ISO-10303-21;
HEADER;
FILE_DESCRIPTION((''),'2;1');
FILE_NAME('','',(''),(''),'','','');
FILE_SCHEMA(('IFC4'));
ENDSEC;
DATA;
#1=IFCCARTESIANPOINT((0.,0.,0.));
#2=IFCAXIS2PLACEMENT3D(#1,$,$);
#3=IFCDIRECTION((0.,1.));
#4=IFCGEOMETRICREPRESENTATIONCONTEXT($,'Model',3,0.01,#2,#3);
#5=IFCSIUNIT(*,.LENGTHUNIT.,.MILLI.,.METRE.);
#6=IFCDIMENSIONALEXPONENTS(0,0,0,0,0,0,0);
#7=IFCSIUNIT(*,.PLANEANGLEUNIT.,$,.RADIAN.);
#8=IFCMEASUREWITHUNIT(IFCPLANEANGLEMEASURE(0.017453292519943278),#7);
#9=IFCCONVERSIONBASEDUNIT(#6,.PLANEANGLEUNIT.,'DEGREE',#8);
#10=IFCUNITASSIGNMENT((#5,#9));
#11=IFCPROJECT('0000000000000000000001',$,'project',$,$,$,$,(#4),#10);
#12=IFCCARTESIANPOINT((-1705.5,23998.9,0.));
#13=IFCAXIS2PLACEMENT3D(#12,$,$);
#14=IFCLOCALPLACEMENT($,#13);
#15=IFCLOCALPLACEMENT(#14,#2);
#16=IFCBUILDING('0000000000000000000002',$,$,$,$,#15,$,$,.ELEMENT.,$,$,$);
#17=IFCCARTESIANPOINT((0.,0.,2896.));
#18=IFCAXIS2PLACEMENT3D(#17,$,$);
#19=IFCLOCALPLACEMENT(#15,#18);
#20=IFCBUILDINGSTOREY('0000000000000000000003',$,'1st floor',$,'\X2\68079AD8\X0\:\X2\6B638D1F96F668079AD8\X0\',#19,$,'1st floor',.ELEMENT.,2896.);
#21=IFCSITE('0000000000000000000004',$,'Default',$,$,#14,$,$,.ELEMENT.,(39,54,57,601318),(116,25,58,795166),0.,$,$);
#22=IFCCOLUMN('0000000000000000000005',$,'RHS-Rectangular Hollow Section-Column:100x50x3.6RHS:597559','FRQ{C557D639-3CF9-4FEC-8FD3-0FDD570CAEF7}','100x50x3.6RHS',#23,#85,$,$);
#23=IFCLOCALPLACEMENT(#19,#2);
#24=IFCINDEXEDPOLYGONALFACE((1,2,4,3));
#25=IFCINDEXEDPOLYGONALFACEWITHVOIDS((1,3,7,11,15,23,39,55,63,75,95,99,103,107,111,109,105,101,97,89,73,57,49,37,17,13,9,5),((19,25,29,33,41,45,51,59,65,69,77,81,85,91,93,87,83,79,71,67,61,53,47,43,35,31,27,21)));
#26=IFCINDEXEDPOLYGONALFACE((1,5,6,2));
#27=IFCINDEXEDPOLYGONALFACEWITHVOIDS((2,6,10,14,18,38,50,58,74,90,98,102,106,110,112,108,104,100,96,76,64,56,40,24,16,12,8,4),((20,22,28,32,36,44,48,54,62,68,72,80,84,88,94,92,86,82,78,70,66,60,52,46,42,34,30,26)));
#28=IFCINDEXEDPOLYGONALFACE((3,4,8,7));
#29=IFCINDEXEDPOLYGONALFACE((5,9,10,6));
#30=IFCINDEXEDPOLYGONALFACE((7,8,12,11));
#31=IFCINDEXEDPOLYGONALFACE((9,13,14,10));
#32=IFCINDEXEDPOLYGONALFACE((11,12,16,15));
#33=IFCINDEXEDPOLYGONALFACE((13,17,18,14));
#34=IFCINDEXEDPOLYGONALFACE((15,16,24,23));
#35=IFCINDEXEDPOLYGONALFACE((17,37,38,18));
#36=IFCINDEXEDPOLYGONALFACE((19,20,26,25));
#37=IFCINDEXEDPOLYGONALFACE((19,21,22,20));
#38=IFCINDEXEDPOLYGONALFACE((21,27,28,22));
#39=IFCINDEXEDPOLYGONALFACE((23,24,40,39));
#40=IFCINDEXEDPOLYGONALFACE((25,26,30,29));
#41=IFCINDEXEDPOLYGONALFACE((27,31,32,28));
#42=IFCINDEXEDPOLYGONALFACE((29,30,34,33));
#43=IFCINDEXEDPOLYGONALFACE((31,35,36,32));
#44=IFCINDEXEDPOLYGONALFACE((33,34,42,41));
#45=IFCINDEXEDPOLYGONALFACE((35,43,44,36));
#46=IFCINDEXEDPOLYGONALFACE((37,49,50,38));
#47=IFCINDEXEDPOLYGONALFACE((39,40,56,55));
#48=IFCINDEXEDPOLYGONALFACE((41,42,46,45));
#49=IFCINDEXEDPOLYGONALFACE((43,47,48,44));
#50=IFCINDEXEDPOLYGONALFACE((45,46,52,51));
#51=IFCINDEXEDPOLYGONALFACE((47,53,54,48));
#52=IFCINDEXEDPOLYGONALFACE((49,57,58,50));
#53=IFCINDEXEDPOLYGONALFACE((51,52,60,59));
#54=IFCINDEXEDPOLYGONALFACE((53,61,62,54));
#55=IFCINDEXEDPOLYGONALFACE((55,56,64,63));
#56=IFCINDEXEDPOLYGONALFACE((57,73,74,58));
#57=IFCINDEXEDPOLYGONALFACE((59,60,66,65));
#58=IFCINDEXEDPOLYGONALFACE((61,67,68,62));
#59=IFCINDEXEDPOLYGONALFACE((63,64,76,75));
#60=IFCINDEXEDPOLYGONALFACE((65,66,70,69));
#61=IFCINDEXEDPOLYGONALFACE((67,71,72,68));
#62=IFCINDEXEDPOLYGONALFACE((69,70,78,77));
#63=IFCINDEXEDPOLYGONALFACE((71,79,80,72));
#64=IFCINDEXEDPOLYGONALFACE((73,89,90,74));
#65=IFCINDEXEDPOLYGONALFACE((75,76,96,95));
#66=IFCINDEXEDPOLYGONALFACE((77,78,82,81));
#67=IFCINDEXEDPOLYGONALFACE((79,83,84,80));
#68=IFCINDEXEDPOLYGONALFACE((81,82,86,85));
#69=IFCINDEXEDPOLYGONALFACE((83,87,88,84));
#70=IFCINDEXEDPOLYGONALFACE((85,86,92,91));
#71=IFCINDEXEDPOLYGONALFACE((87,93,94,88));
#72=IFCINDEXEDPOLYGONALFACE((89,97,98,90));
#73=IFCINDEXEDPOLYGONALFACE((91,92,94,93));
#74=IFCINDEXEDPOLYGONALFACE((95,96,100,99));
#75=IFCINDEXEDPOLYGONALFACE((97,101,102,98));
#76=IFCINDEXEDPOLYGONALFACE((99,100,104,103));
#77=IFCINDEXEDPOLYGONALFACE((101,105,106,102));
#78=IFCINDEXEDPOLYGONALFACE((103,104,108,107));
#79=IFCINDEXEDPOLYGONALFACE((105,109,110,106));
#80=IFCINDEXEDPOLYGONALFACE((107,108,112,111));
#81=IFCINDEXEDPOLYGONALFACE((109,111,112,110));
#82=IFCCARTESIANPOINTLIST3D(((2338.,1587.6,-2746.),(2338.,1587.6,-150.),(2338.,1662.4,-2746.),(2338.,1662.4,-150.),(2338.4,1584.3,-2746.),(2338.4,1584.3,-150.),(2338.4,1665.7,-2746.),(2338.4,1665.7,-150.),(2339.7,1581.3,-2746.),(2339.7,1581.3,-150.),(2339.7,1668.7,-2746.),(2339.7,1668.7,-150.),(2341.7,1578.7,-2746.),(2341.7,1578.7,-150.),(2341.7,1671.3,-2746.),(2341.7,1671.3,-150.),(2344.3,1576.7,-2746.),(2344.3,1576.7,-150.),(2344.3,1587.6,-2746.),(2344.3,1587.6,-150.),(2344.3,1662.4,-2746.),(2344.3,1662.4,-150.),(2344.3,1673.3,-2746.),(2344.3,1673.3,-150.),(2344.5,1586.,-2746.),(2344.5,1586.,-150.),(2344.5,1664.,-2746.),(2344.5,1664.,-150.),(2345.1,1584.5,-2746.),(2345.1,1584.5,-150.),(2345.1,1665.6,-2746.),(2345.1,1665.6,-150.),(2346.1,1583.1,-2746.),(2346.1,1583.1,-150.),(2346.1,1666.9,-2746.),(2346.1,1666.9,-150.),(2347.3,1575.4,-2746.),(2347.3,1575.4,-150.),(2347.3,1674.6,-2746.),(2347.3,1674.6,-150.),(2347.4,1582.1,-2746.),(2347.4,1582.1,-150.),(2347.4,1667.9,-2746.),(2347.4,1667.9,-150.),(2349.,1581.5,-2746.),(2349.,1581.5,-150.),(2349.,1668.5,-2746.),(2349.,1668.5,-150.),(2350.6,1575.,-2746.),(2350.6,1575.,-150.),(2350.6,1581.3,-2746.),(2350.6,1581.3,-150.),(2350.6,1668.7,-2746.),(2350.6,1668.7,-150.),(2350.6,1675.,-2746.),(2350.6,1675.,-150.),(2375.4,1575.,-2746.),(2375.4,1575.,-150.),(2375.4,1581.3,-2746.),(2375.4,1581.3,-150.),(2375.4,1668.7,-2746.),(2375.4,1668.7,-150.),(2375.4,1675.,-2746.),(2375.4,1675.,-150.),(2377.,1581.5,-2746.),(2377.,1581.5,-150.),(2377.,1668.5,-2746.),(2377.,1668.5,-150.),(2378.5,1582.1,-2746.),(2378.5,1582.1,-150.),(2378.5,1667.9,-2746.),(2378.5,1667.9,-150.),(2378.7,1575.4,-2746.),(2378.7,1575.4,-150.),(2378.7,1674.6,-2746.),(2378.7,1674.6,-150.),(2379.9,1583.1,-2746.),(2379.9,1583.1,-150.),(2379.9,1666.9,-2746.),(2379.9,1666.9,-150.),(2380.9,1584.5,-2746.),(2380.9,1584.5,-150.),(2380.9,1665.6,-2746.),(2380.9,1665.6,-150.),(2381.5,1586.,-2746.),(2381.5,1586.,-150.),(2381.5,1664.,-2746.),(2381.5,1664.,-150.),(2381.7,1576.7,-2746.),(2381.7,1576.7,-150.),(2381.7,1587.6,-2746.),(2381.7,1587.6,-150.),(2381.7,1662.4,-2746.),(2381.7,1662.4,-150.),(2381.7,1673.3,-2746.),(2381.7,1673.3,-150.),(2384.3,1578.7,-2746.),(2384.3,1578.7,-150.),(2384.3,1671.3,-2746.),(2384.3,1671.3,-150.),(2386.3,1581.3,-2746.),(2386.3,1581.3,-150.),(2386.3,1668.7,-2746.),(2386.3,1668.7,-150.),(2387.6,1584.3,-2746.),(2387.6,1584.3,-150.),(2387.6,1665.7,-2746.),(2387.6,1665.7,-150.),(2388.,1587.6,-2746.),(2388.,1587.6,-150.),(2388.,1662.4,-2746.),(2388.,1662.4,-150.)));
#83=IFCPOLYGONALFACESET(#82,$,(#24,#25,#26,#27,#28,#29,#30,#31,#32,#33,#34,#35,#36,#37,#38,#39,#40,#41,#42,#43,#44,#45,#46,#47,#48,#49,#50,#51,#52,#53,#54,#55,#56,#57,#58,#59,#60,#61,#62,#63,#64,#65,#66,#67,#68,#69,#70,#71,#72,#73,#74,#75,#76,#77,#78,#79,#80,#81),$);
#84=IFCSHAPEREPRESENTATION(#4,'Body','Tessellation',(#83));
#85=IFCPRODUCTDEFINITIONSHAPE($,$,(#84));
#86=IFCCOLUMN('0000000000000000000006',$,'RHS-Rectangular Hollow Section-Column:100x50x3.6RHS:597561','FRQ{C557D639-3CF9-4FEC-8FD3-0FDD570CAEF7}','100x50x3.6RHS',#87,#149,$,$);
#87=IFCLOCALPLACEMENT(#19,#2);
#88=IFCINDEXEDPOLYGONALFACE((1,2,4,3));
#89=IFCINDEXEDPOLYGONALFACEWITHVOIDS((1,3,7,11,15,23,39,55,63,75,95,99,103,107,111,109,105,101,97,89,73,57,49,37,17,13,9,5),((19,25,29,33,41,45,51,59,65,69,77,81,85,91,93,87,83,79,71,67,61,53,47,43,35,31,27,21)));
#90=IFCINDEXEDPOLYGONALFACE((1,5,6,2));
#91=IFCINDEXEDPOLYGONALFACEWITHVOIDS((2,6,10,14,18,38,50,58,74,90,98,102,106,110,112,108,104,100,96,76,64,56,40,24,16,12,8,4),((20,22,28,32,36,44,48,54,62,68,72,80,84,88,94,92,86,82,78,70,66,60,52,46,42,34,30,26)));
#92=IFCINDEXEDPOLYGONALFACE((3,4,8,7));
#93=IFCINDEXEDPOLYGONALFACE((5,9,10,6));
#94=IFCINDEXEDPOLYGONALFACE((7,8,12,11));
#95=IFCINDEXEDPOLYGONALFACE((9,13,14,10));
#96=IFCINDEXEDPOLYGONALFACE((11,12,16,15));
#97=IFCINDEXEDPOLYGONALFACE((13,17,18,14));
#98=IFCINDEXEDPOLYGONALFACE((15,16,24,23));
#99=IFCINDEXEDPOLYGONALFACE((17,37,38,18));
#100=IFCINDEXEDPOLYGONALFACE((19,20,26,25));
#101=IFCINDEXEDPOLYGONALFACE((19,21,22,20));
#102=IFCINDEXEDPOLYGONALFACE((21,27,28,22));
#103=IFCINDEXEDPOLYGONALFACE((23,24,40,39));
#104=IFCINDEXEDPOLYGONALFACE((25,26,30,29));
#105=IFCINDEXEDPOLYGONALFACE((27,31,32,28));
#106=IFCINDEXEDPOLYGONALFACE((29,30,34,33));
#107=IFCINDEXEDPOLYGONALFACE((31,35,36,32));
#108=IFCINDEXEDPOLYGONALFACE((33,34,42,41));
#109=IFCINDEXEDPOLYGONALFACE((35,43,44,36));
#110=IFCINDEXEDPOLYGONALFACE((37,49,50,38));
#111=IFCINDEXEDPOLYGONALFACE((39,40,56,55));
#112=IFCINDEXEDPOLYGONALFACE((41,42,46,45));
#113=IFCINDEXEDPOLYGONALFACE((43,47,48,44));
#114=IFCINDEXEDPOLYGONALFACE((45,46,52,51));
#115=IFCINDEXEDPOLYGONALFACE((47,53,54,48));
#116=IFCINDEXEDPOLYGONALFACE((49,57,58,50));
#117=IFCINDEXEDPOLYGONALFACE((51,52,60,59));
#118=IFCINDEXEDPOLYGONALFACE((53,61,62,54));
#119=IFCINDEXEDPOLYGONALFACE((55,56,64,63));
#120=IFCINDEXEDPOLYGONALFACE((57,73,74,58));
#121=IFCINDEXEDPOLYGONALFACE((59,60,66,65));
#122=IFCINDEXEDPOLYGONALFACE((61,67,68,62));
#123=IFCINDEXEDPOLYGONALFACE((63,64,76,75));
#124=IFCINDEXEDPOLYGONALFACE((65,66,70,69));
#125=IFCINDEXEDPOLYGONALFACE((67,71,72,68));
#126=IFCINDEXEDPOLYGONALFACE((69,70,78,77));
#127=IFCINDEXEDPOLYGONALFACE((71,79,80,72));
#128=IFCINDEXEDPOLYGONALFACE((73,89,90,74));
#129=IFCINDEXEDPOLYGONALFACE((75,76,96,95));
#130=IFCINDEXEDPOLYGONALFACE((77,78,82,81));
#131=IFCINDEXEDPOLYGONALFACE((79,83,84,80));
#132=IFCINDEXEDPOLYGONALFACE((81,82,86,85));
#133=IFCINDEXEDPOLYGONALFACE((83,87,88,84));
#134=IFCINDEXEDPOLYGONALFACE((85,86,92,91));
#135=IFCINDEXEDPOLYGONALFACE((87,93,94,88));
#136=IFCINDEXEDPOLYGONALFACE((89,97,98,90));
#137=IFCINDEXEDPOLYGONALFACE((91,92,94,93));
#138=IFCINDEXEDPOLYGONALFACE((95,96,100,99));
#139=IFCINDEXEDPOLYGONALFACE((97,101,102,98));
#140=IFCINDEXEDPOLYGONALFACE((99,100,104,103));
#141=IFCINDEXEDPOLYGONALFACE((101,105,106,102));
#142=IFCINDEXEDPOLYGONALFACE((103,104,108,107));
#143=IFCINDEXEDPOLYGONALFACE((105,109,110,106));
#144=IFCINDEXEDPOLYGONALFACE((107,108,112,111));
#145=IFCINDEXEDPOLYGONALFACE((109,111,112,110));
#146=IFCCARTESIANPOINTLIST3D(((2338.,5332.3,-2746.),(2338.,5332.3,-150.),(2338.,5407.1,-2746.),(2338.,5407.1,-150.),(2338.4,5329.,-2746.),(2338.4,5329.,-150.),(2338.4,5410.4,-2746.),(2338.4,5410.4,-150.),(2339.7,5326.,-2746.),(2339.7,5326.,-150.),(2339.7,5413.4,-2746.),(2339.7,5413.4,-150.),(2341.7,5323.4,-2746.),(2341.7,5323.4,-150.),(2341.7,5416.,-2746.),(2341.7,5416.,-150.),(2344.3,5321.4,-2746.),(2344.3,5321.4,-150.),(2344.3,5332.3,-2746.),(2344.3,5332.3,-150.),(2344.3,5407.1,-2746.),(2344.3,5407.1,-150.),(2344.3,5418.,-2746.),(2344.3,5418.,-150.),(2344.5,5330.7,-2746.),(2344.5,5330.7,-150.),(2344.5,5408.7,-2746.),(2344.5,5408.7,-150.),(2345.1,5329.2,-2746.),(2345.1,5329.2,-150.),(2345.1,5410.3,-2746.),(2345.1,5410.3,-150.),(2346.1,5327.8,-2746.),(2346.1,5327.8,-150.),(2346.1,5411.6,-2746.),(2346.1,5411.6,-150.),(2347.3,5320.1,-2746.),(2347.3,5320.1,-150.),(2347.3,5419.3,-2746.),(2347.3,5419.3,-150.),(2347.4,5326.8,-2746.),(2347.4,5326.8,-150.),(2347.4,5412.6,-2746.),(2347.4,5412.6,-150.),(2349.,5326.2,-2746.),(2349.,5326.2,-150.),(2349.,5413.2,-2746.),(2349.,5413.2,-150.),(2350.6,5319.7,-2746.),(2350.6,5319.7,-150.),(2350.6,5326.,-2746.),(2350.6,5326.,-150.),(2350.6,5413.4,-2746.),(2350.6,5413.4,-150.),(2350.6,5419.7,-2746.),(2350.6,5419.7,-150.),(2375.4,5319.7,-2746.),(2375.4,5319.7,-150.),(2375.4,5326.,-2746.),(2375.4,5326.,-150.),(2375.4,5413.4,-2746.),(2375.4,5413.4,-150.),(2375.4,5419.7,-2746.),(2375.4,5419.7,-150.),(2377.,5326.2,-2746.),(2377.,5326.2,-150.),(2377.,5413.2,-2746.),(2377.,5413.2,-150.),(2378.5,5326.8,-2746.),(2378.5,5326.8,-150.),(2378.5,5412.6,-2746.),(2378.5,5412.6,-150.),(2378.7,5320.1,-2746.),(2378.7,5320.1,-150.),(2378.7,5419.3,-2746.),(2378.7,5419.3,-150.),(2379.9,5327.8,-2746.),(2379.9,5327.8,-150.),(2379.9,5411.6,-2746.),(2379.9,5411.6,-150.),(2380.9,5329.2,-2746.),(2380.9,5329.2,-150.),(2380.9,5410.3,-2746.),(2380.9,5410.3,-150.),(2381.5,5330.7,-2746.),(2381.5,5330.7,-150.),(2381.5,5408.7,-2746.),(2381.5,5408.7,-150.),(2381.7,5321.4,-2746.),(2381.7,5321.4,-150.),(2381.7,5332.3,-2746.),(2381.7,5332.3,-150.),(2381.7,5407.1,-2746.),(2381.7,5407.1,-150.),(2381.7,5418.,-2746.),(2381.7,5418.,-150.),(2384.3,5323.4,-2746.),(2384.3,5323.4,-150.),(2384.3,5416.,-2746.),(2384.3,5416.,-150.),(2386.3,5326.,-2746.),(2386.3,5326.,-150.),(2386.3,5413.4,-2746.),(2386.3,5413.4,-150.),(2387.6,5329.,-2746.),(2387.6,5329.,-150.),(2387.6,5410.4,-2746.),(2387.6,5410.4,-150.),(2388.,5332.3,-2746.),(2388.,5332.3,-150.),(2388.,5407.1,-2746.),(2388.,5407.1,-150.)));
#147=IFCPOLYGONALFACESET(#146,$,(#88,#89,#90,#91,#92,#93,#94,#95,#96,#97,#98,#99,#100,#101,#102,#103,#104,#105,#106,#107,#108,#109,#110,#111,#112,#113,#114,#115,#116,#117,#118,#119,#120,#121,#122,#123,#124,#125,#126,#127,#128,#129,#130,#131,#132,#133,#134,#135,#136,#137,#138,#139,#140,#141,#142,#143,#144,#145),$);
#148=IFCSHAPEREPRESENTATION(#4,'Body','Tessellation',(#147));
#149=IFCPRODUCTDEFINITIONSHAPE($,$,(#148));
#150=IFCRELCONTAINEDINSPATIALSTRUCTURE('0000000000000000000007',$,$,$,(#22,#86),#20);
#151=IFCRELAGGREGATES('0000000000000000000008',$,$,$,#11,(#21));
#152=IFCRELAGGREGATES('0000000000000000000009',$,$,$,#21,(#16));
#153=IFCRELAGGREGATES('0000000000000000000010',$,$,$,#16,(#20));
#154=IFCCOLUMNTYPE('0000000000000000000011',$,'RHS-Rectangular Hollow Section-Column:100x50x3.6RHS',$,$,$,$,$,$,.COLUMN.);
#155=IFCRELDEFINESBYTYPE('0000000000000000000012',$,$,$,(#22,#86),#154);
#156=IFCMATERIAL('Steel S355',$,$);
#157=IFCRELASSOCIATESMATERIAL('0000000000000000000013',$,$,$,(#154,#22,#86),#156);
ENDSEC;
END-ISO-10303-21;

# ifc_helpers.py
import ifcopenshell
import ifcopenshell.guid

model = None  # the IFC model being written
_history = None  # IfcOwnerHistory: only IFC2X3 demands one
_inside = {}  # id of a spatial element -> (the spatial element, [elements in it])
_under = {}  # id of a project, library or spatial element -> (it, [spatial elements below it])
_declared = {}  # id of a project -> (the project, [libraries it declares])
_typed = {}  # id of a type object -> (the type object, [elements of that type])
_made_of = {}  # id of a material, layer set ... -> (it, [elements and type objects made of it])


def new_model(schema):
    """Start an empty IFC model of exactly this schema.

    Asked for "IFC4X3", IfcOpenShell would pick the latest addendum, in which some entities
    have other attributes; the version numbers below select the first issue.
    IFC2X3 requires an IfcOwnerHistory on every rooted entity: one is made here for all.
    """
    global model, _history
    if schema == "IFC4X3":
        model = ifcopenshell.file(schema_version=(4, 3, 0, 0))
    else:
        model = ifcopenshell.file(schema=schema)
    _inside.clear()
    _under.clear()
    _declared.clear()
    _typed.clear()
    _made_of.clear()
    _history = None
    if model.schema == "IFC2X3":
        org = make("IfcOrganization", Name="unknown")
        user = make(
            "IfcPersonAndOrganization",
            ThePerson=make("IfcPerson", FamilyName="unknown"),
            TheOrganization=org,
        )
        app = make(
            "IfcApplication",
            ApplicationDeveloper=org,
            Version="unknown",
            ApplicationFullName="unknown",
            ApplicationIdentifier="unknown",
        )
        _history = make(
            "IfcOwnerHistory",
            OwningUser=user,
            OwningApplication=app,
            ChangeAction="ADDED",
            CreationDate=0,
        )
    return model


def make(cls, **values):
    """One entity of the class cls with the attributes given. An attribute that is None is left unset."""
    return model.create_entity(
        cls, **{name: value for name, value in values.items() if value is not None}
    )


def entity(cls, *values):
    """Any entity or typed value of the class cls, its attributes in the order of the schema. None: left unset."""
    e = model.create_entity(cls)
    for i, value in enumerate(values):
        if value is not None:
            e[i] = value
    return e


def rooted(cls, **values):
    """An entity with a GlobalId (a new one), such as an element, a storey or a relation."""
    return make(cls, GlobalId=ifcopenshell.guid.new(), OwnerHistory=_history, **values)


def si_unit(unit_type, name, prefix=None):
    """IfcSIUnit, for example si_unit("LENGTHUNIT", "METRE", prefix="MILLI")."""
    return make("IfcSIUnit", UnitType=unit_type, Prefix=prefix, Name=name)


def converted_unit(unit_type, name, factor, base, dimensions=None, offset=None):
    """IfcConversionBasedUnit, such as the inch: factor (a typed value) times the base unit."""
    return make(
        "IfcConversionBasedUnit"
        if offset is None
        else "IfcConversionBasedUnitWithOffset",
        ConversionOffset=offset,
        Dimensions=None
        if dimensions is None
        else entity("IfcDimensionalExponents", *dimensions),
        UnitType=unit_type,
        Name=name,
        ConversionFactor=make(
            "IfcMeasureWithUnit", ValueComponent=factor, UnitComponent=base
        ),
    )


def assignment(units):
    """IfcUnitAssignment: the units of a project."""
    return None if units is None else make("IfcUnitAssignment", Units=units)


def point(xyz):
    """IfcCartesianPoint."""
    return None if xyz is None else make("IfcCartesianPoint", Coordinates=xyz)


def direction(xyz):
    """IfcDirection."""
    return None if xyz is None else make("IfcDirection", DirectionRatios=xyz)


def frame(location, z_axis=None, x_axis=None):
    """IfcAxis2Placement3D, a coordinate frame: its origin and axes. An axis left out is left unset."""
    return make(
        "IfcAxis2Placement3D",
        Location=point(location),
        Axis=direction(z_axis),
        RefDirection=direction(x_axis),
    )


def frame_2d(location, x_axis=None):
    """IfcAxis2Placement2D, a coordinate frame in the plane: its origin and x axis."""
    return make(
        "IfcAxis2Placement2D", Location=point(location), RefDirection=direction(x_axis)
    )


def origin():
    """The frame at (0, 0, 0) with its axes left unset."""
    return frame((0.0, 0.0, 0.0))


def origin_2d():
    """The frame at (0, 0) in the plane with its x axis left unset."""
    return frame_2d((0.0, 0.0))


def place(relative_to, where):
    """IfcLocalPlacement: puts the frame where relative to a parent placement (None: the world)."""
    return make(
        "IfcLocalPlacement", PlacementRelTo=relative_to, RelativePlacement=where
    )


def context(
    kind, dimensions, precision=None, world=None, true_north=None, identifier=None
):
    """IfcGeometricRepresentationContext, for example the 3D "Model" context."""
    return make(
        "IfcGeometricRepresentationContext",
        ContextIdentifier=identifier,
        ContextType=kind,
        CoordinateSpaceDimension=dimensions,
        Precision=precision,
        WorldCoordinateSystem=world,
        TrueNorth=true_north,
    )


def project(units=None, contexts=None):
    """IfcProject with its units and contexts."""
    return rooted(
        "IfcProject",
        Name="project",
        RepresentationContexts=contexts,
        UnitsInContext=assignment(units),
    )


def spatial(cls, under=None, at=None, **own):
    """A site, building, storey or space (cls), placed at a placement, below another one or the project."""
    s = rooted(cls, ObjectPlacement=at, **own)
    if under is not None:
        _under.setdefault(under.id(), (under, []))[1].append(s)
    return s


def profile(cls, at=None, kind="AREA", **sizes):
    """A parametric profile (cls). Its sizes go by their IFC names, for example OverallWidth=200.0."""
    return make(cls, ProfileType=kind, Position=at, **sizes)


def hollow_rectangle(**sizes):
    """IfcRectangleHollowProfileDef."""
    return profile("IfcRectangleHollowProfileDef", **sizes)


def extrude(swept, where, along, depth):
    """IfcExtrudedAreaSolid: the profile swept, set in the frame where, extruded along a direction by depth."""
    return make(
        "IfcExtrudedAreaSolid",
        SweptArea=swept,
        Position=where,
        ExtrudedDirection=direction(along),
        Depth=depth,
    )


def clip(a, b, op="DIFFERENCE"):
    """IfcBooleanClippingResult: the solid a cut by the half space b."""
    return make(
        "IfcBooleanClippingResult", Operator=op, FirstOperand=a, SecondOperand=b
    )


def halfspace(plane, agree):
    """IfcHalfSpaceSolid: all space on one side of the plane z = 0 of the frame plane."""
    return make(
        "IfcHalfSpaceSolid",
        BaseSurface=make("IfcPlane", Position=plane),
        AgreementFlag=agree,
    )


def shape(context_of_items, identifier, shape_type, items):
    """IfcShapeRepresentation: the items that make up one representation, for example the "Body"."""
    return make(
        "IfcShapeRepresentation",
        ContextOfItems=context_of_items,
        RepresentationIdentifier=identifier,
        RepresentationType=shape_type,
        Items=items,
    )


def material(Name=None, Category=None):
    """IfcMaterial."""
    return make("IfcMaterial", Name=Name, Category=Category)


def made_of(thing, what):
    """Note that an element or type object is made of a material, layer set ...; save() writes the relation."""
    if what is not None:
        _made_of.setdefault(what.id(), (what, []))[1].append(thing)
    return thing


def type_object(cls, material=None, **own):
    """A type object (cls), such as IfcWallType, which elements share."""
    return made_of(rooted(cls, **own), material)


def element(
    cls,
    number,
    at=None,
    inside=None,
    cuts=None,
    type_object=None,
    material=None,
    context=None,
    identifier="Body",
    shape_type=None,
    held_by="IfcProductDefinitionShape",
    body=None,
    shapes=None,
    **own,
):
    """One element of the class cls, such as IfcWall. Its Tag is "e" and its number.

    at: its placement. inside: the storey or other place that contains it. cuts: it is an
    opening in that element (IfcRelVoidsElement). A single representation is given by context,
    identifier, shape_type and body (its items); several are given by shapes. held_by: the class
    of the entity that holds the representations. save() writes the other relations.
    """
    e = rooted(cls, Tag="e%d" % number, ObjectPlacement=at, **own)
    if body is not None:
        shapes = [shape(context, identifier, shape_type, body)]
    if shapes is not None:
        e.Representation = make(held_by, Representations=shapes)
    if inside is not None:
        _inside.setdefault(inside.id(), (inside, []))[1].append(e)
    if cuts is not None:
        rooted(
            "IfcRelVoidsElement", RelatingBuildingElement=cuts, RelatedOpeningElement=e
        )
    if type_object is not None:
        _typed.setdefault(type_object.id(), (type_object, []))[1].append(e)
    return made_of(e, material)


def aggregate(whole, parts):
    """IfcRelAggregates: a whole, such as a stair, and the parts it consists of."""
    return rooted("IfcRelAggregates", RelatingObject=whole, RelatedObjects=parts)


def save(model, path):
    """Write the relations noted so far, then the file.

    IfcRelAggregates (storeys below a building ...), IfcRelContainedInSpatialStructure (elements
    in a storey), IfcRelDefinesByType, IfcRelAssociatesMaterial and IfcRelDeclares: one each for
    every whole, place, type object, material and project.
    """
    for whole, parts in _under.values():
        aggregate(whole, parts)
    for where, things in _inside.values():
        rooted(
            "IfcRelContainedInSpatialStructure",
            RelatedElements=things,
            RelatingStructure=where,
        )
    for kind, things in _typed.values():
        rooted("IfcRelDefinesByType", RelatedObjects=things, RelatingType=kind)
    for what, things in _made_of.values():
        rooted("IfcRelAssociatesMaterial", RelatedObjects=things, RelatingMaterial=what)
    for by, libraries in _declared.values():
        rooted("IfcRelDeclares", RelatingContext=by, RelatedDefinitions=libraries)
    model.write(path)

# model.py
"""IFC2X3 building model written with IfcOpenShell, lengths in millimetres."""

from ifc_helpers import new_model, entity, si_unit, converted_unit, direction, frame, origin, origin_2d, place, context, project, spatial, hollow_rectangle, extrude, clip, halfspace, material, type_object, element, save


model = new_model("IFC2X3")

# Units and contexts
model_context = context("Model", 3, precision=0.01, world=origin(), true_north=direction((0.0, 1.0)))
ifc_project = project(units=[si_unit("LENGTHUNIT", "METRE", prefix="MILLI"), converted_unit("PLANEANGLEUNIT", "DEGREE", entity("IfcPlaneAngleMeasure", 0.017453292519943278), si_unit("PLANEANGLEUNIT", "RADIAN"), dimensions=[0, 0, 0, 0, 0, 0, 0])], contexts=[model_context])

# Site, building, storey
site_placement = place(None, frame((-1705.5, 23998.9, 0.0)))
site = spatial("IfcSite", under=ifc_project, at=site_placement, Name="Default", CompositionType="ELEMENT", RefLatitude=(39, 54, 57, 601318), RefLongitude=(116, 25, 58, 795166), RefElevation=0.0)
building_placement = place(site_placement, origin())
building = spatial("IfcBuilding", under=site, at=building_placement, CompositionType="ELEMENT")
storey_placement = place(building_placement, frame((0.0, 0.0, 2896.0)))
storey = spatial("IfcBuildingStorey", under=building, at=storey_placement, Name="1st floor", ObjectType="标高:正负零标高", LongName="1st floor", CompositionType="ELEMENT", Elevation=2896.0)

# Columns
ifc_material_1 = material(Name="Steel S355")
column_type_1 = type_object("IfcColumnType", Name="RHS-Rectangular Hollow Section-Column:100x50x3.6RHS", PredefinedType="COLUMN", material=ifc_material_1)
column_1_placement = place(storey_placement, frame((2363.0, 1625.0, -150.0), z_axis=(0.0, 0.0, 1.0), x_axis=(-1.0, 0.0, 0.0)))
element("IfcColumn", 1, at=column_1_placement, inside=storey, type_object=column_type_1, material=ifc_material_1, Name="RHS-Rectangular Hollow Section-Column:100x50x3.6RHS:597559", Description="FRQ{C557D639-3CF9-4FEC-8FD3-0FDD570CAEF7}", ObjectType="100x50x3.6RHS", context=model_context, shape_type="Clipping", body=[
    clip(extrude(hollow_rectangle(XDim=50.0, YDim=100.0, WallThickness=6.3, InnerFilletRadius=6.3, OuterFilletRadius=12.6, at=origin_2d()), origin(), (0.0, 0.0, -1.0), 2651.9), halfspace(frame((2363.0, 1625.0, -2596.0), z_axis=(0.0, 0.0, 1.0), x_axis=(-1.0, 0.0, 0.0)), True)),
])
column_2_placement = place(storey_placement, frame((2363.0, 5369.7, -150.0), z_axis=(0.0, 0.0, 1.0), x_axis=(-1.0, 0.0, 0.0)))
element("IfcColumn", 2, at=column_2_placement, inside=storey, type_object=column_type_1, material=ifc_material_1, Name="RHS-Rectangular Hollow Section-Column:100x50x3.6RHS:597561", Description="FRQ{C557D639-3CF9-4FEC-8FD3-0FDD570CAEF7}", ObjectType="100x50x3.6RHS", context=model_context, shape_type="Clipping", body=[
    clip(extrude(hollow_rectangle(XDim=50.0, YDim=100.0, WallThickness=6.3, InnerFilletRadius=6.3, OuterFilletRadius=12.6, at=origin_2d()), origin(), (0.0, 0.0, -1.0), 2651.9), halfspace(frame((2363.0, 5369.7, -2596.0), z_axis=(0.0, 0.0, 1.0), x_axis=(-1.0, 0.0, 0.0)), True)),
])

save(model, "model.ifc")
